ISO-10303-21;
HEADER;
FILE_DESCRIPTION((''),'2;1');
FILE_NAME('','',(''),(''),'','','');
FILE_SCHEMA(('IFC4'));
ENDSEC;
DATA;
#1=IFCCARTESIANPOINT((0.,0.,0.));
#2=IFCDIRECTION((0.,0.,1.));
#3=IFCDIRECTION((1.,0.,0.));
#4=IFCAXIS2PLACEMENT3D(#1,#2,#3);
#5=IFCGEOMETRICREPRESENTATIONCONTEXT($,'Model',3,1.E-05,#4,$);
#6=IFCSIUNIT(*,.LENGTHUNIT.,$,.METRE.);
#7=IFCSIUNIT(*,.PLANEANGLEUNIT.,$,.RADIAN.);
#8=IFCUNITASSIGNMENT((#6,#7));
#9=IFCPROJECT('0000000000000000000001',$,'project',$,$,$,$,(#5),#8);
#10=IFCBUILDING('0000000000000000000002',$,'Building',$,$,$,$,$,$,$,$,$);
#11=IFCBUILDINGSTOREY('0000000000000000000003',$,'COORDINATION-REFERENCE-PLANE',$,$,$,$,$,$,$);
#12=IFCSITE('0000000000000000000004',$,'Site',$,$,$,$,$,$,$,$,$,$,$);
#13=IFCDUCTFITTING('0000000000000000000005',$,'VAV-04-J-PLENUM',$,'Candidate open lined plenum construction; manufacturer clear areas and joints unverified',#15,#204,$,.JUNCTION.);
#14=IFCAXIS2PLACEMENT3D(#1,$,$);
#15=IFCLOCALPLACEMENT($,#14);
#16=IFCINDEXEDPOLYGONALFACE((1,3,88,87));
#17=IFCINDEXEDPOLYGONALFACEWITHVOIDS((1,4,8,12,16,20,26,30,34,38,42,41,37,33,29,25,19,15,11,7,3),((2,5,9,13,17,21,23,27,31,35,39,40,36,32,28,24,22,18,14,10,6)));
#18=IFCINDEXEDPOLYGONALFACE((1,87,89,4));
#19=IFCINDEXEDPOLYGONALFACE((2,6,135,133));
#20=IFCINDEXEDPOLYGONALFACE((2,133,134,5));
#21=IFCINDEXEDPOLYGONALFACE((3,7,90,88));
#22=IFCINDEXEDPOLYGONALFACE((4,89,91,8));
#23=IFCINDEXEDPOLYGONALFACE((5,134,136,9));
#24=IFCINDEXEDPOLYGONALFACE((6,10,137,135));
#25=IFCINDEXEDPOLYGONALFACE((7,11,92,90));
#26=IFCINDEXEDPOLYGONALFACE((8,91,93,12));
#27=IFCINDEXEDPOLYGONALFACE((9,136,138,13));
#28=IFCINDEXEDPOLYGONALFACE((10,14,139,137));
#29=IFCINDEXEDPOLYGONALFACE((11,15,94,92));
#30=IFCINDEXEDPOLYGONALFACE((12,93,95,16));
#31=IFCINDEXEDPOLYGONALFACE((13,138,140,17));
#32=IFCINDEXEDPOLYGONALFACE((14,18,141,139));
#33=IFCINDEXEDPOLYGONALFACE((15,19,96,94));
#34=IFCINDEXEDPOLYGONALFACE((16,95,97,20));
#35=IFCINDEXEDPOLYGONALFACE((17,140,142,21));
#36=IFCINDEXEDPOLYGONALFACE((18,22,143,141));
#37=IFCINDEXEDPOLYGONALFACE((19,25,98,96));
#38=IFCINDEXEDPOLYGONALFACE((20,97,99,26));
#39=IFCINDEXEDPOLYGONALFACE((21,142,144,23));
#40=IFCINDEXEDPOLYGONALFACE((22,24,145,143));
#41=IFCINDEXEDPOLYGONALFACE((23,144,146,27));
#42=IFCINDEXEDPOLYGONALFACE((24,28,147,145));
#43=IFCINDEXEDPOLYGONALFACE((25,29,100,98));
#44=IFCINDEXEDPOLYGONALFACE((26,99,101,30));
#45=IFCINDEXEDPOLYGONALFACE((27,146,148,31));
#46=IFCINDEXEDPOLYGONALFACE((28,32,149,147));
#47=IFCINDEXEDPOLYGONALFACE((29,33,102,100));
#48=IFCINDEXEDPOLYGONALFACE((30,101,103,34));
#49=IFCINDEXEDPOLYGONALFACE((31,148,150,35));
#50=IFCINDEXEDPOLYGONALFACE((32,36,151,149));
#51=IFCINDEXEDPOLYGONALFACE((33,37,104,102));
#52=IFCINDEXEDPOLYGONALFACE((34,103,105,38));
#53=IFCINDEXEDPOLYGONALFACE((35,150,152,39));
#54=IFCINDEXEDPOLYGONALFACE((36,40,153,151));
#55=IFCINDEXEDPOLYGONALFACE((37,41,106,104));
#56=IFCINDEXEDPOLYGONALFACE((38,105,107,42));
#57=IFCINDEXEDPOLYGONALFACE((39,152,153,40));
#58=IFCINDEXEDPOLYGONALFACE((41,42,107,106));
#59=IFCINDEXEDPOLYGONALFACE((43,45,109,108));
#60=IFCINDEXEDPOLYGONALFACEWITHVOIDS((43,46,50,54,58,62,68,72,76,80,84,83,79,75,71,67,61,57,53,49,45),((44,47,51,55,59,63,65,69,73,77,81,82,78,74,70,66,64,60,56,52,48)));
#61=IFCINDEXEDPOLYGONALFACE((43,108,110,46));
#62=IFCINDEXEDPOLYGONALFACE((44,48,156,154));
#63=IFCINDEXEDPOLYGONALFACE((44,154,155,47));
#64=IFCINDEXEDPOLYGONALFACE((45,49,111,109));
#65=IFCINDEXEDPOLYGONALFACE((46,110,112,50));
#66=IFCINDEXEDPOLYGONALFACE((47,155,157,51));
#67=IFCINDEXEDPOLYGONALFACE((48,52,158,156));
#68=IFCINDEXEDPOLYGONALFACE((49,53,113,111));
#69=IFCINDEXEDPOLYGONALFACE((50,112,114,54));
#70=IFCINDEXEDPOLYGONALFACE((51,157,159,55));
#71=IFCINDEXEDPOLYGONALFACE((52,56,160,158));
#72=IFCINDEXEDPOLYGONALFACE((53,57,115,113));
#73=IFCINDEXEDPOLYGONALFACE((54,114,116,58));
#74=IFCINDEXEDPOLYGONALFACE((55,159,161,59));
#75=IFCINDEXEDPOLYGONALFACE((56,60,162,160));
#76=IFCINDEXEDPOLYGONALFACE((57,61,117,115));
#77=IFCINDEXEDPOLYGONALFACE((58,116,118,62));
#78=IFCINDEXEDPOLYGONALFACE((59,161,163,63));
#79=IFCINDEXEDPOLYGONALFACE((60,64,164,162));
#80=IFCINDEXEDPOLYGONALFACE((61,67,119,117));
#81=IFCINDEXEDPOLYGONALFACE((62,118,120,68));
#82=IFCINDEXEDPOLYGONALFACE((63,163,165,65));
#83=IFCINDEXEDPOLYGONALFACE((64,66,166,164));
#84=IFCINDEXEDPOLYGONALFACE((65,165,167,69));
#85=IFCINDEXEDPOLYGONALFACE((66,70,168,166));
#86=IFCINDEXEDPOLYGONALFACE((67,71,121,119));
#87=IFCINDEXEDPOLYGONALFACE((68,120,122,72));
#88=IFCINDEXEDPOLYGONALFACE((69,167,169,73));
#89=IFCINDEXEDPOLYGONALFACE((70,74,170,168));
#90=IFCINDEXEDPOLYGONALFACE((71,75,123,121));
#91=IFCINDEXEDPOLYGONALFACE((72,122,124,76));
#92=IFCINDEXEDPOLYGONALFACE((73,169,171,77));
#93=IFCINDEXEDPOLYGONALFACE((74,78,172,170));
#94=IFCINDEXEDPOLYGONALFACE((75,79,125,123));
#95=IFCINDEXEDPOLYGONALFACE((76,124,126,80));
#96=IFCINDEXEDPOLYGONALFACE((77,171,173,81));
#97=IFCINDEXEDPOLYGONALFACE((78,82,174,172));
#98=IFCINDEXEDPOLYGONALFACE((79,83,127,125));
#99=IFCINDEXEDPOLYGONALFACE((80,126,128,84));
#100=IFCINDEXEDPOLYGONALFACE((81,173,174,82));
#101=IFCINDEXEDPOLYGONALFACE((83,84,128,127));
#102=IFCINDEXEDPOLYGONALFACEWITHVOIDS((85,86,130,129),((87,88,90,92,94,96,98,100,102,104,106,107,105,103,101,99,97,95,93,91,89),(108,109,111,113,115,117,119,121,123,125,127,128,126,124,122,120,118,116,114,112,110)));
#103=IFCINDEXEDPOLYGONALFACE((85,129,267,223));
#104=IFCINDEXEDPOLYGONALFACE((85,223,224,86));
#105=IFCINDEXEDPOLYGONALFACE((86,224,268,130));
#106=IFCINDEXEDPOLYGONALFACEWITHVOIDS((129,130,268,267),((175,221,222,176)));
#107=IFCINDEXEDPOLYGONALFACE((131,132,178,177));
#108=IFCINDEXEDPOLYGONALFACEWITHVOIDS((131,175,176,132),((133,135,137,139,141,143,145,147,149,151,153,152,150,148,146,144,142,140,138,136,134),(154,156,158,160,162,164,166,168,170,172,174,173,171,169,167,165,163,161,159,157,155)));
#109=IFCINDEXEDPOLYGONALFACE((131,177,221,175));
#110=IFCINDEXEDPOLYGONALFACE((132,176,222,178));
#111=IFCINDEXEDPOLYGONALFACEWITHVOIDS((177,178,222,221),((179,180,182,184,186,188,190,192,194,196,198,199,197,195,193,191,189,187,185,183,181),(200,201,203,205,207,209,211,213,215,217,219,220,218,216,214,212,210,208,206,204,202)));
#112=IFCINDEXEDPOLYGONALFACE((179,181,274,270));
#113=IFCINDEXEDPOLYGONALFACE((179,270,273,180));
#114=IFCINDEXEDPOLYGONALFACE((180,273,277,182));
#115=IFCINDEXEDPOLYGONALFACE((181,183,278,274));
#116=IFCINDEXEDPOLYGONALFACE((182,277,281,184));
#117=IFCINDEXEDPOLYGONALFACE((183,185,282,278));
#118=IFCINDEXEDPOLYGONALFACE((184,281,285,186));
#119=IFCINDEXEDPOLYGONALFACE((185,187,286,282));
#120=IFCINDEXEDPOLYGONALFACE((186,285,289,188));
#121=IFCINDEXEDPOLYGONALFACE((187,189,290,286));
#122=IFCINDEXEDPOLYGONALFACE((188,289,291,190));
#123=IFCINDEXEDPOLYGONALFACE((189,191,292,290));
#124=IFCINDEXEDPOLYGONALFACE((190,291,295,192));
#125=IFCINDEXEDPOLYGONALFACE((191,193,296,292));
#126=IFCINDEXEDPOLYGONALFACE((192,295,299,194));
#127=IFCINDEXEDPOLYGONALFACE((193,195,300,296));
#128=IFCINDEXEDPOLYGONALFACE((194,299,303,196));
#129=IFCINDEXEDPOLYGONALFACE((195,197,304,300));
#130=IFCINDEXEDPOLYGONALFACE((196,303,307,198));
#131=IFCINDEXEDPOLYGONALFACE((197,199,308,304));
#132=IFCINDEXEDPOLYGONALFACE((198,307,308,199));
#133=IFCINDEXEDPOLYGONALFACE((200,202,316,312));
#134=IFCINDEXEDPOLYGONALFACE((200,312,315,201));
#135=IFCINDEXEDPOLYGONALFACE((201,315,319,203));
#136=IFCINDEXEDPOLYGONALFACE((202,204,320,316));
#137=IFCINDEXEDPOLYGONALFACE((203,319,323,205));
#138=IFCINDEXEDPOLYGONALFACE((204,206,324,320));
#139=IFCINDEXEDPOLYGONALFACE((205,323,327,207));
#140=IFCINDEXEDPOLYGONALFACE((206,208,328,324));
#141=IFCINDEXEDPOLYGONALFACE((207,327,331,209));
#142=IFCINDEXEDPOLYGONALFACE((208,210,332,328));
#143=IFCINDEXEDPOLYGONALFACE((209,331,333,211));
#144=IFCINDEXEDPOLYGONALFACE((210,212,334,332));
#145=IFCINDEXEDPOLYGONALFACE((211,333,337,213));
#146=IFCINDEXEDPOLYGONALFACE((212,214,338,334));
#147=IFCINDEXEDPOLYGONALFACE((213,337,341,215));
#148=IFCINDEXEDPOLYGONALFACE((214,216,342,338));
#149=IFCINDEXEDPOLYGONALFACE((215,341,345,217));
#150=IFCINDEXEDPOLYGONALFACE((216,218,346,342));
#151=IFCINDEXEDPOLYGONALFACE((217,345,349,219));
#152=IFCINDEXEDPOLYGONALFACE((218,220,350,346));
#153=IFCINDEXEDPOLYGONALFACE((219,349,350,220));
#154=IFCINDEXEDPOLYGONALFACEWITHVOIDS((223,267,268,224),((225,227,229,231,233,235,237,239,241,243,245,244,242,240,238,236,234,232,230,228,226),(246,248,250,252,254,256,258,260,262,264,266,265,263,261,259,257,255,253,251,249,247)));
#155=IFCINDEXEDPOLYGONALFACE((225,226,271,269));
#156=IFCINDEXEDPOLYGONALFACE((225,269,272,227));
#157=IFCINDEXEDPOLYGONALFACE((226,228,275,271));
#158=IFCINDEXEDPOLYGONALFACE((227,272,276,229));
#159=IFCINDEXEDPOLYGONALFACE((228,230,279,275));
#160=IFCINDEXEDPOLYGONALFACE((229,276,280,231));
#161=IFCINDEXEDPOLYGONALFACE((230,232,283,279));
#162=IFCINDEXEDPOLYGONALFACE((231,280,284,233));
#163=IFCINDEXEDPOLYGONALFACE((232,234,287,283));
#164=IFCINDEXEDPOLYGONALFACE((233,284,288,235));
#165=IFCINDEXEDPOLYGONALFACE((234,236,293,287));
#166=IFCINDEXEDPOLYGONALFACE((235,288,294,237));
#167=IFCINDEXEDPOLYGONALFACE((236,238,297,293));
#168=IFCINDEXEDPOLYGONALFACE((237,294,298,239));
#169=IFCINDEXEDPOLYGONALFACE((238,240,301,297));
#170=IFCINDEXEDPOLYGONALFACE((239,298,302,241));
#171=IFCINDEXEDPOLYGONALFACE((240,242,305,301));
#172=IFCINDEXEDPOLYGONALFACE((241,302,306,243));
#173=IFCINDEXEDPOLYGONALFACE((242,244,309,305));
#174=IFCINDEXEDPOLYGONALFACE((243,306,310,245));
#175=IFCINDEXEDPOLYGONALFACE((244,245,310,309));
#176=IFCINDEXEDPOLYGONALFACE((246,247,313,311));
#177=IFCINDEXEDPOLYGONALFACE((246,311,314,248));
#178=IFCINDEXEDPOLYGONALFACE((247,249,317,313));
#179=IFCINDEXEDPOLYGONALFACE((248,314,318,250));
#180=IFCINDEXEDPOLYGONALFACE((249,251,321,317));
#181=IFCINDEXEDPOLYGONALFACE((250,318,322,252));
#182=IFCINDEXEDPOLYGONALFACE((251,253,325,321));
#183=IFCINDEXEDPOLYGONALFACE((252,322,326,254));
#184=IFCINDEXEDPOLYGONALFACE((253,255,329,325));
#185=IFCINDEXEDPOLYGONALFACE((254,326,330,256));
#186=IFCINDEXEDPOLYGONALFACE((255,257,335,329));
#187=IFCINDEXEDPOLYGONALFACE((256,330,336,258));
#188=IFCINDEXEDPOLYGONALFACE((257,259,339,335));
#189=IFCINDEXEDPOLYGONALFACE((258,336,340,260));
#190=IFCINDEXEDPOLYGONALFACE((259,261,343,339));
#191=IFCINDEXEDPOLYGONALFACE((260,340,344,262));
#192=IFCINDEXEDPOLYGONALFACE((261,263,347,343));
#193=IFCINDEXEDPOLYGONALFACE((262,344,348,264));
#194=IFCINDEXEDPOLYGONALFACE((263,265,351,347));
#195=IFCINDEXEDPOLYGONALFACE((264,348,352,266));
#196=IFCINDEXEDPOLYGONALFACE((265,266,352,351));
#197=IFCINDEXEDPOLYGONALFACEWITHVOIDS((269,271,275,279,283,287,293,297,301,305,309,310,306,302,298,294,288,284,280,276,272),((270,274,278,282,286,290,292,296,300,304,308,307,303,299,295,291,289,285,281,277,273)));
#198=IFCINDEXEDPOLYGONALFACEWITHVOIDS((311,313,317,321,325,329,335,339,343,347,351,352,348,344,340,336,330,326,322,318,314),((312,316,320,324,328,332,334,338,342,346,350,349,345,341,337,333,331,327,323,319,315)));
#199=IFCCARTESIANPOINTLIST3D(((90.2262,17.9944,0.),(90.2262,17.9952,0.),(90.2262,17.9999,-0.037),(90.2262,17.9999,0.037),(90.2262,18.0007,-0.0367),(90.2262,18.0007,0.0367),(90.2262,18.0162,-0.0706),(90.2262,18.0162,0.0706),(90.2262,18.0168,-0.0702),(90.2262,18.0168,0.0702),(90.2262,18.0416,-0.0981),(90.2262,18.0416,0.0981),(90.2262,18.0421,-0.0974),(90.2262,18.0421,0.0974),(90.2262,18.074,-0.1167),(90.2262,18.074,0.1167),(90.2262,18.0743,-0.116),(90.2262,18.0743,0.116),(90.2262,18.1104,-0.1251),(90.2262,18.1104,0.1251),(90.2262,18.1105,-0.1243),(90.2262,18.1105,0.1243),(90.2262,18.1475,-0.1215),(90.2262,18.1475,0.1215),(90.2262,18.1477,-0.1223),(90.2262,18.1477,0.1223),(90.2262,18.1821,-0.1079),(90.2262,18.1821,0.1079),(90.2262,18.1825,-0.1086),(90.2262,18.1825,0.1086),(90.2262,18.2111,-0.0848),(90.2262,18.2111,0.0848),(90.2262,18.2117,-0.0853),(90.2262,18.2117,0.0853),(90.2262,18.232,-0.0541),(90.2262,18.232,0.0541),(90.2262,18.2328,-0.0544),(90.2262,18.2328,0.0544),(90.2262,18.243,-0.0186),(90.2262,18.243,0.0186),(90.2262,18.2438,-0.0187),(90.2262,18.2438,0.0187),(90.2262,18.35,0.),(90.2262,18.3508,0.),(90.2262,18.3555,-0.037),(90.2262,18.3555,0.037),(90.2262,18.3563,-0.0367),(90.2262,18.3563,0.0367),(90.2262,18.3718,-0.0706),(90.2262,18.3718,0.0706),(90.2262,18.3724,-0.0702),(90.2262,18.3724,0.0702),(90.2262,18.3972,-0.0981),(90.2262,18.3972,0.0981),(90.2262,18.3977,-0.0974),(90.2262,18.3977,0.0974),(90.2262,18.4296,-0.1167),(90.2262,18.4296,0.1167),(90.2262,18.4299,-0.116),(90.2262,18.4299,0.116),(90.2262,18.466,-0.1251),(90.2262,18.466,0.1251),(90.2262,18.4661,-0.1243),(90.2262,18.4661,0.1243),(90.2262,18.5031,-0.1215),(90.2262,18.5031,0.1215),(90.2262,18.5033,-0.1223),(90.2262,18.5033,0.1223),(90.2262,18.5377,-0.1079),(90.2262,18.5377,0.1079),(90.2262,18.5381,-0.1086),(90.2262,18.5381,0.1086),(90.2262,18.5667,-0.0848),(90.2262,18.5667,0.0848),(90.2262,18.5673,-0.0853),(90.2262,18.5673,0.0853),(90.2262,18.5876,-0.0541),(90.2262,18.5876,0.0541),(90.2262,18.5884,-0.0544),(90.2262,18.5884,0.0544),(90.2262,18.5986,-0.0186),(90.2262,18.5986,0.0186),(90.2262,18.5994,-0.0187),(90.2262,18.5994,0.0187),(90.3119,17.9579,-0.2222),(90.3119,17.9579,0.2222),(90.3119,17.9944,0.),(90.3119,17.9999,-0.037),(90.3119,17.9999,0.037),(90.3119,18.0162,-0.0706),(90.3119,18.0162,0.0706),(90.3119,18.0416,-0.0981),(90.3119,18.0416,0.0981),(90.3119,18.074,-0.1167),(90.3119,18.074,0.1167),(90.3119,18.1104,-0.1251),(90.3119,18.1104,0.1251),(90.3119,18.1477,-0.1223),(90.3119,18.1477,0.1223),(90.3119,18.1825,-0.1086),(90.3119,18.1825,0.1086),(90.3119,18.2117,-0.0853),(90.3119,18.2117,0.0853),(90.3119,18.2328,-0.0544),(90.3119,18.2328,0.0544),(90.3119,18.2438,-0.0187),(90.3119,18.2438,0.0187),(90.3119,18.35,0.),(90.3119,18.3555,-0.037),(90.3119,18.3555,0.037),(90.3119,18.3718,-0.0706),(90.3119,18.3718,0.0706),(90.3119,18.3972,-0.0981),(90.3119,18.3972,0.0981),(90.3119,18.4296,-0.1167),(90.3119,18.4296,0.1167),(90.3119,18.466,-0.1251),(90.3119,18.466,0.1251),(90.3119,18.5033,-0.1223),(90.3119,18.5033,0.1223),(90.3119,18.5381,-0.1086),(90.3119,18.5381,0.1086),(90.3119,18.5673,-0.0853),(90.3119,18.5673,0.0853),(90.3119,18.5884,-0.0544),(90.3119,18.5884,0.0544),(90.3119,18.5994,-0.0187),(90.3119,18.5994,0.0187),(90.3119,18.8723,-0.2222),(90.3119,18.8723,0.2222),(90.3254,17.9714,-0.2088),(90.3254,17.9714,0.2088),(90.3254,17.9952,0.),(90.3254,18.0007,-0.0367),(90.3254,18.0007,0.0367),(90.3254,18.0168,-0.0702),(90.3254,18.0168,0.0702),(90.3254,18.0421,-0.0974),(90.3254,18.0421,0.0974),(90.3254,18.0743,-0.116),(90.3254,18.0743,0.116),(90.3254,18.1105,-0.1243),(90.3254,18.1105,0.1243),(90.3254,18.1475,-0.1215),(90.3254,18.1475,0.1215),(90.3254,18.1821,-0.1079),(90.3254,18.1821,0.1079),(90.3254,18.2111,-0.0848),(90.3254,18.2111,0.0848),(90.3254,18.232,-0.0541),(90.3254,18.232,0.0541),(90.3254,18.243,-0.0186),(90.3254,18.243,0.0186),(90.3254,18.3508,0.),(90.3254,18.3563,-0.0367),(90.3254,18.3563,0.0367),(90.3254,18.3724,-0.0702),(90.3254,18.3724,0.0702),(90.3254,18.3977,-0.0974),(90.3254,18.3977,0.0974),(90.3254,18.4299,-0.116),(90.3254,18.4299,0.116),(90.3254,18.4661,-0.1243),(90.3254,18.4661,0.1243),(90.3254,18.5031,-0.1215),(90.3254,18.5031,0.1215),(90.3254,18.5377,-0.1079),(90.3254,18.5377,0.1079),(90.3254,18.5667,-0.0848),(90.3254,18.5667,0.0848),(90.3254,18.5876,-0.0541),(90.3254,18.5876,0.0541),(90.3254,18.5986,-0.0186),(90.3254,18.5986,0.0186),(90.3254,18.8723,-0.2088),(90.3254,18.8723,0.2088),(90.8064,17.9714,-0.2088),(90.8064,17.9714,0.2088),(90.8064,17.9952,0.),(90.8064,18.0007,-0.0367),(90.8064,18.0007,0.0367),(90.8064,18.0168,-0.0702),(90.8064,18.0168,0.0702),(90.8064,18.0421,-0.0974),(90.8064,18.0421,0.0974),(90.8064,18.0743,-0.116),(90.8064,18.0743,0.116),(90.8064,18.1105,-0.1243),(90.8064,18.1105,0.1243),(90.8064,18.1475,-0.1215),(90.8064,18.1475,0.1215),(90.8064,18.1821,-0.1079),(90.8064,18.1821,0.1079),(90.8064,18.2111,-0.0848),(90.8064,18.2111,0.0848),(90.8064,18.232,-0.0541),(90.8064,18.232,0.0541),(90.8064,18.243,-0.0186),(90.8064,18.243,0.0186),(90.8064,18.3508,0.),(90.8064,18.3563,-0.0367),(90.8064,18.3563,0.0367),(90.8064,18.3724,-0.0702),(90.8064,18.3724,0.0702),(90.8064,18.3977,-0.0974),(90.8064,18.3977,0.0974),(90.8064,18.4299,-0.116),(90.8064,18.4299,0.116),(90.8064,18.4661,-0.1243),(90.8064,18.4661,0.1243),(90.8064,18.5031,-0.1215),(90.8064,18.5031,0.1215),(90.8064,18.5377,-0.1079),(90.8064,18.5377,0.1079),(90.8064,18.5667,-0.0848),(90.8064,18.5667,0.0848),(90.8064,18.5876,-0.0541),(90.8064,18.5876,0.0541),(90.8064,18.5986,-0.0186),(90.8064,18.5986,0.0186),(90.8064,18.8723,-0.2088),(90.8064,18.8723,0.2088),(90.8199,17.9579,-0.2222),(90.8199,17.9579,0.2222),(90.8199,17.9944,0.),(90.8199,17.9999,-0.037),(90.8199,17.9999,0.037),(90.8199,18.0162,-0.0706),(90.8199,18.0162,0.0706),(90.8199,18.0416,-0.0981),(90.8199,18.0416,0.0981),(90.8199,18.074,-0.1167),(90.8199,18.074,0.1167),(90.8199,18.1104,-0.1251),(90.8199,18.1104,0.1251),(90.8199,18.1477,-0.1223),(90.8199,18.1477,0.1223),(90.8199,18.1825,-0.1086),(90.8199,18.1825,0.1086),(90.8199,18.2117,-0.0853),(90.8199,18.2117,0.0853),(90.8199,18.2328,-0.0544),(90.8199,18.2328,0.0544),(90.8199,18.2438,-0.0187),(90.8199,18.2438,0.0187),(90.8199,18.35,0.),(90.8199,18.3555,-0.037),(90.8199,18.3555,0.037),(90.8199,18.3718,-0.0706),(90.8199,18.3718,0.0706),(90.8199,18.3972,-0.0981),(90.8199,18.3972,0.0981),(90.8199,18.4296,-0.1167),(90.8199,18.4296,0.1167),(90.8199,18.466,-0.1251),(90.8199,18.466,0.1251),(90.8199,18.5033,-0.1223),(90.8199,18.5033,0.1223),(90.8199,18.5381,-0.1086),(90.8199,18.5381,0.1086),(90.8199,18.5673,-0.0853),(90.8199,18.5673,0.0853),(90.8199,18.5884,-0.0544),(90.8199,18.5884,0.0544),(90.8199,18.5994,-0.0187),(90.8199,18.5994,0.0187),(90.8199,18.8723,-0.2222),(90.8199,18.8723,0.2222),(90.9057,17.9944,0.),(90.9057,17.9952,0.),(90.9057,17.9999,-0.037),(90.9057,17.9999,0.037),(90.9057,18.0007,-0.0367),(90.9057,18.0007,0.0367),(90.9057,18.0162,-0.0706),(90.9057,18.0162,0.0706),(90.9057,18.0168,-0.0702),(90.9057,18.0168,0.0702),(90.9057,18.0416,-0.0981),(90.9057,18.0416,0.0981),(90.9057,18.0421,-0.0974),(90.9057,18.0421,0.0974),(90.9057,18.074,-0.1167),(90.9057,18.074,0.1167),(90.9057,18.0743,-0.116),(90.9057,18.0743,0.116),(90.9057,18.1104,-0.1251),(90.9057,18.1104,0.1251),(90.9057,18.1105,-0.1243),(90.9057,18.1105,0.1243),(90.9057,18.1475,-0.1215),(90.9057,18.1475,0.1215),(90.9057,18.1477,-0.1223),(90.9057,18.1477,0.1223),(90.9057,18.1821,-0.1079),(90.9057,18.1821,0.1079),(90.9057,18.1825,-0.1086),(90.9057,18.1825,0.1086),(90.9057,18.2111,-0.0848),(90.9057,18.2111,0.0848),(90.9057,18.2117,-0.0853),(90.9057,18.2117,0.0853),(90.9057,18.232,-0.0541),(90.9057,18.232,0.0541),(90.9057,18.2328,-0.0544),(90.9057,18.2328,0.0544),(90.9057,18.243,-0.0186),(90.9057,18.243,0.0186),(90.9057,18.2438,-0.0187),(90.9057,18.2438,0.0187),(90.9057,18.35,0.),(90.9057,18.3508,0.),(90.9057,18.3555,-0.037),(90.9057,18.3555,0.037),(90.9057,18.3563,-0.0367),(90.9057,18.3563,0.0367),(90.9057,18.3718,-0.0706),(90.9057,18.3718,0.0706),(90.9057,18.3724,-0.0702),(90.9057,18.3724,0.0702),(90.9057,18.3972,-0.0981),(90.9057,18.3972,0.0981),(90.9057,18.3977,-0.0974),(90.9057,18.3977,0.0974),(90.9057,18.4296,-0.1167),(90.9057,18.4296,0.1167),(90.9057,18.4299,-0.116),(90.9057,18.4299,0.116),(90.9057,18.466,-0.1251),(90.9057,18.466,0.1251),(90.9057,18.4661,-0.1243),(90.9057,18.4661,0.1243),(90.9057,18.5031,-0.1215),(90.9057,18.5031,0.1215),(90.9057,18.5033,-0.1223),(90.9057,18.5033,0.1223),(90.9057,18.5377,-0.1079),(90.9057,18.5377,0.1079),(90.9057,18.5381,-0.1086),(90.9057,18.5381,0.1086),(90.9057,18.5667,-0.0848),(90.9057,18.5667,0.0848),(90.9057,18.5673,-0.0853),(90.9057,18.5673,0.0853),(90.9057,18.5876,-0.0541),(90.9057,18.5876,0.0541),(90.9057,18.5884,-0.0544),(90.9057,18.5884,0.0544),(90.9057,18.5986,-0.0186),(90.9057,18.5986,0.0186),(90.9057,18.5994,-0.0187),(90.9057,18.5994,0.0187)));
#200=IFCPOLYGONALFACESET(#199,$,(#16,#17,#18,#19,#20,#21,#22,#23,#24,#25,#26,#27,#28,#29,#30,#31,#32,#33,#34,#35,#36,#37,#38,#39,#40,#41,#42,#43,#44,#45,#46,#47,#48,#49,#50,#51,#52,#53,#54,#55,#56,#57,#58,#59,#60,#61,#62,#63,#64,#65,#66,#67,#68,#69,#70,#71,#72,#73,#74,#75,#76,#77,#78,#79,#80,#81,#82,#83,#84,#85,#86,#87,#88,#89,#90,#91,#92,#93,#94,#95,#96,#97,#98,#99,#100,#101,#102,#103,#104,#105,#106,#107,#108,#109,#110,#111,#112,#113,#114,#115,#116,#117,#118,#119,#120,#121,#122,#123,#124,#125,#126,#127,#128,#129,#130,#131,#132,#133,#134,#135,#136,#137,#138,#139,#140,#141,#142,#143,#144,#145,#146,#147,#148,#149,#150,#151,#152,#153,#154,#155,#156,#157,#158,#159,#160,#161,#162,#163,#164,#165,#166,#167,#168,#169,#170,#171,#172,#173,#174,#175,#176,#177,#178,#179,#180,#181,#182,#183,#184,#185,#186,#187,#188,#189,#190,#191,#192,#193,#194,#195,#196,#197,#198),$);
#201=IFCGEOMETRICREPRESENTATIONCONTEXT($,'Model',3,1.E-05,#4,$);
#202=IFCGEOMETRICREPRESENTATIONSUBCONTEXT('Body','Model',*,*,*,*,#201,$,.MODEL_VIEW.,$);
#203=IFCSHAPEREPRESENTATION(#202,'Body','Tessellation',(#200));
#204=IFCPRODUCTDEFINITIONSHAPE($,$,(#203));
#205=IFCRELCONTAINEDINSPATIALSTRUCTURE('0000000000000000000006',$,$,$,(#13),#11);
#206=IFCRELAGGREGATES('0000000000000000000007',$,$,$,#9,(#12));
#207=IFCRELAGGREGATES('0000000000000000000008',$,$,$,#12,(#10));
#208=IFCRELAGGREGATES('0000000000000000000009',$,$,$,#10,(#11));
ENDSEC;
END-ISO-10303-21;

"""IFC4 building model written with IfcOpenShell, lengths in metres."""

from ifc_helpers import new_model, si_unit, frame, origin_with_axes, place, context, subcontext, project, spatial, rectangle, circle, extrude, boolean, element, save


model = new_model("IFC4")

# Units and contexts
model_context_1 = context("Model", 3, precision=1e-05, world=origin_with_axes())
model_context_2 = context("Model", 3, precision=1e-05, world=origin_with_axes())
body_context_1 = subcontext(model_context_2, "Body", "Model", "MODEL_VIEW")
ifc_project = project(units=[si_unit("LENGTHUNIT", "METRE"), si_unit("PLANEANGLEUNIT", "RADIAN")], contexts=[model_context_1])

# Site, building, storey
site = spatial("IfcSite", under=ifc_project, Name="Site")
building = spatial("IfcBuilding", under=site, Name="Building")
storey = spatial("IfcBuildingStorey", under=building, Name="COORDINATION-REFERENCE-PLANE")

# Duct fitting
duct_fitting_1_placement = place(None, frame((90.3119, 17.9579, -0.2223), z_axis=(0.0, 0.0, 1.0), x_axis=(1.0, 0.0, 0.0)))
solid_1 = boolean("UNION", boolean("UNION", boolean("UNION", boolean("UNION", extrude(rectangle(XDim=0.481, YDim=0.4175), frame((0.254, 0.9244, 0.2223), z_axis=(0.0, -1.0, 0.0), x_axis=(1.0, 0.0, 0.0)), (0.0, 0.0, 1.0), 0.9109), extrude(circle(Radius=0.1246), frame((0.0235, 0.5175, 0.2223), z_axis=(-1.0, 0.0, 0.0), x_axis=(0.0, -1.0, 0.0)), (0.0, 0.0, 1.0), 0.1192)), extrude(circle(Radius=0.1246), frame((0.4845, 0.5175, 0.2223), z_axis=(1.0, 0.0, 0.0), x_axis=(0.0, -1.0, 0.0)), (0.0, 0.0, 1.0), 0.1192)), extrude(circle(Radius=0.1246), frame((0.0235, 0.1619, 0.2223), z_axis=(-1.0, 0.0, 0.0), x_axis=(0.0, -1.0, 0.0)), (0.0, 0.0, 1.0), 0.1192)), extrude(circle(Radius=0.1246), frame((0.4845, 0.1619, 0.2223), z_axis=(1.0, 0.0, 0.0), x_axis=(0.0, -1.0, 0.0)), (0.0, 0.0, 1.0), 0.1192))
element("IfcDuctFitting", 1, at=duct_fitting_1_placement, inside=storey, Name="VAV-04-J-PLENUM", ObjectType="Candidate open lined plenum construction; manufacturer clear areas and joints unverified", PredefinedType="JUNCTION", context=body_context_1, shape_type="CSG", body=[
    boolean("DIFFERENCE", boolean("UNION", boolean("UNION", boolean("UNION", boolean("UNION", extrude(rectangle(XDim=0.508, YDim=0.4445), frame((0.254, 0.9144, 0.2223), z_axis=(0.0, -1.0, 0.0), x_axis=(1.0, 0.0, 0.0)), (0.0, 0.0, 1.0), 0.9144), extrude(circle(Radius=0.1254), frame((0.0235, 0.5175, 0.2223), z_axis=(-1.0, 0.0, 0.0), x_axis=(0.0, -1.0, 0.0)), (0.0, 0.0, 1.0), 0.1092)), extrude(circle(Radius=0.1254), frame((0.4845, 0.5175, 0.2223), z_axis=(1.0, 0.0, 0.0), x_axis=(0.0, -1.0, 0.0)), (0.0, 0.0, 1.0), 0.1092)), extrude(circle(Radius=0.1254), frame((0.0235, 0.1619, 0.2223), z_axis=(-1.0, 0.0, 0.0), x_axis=(0.0, -1.0, 0.0)), (0.0, 0.0, 1.0), 0.1092)), extrude(circle(Radius=0.1254), frame((0.4845, 0.1619, 0.2223), z_axis=(1.0, 0.0, 0.0), x_axis=(0.0, -1.0, 0.0)), (0.0, 0.0, 1.0), 0.1092)), solid_1),
])

save(model, "model.ifc")
